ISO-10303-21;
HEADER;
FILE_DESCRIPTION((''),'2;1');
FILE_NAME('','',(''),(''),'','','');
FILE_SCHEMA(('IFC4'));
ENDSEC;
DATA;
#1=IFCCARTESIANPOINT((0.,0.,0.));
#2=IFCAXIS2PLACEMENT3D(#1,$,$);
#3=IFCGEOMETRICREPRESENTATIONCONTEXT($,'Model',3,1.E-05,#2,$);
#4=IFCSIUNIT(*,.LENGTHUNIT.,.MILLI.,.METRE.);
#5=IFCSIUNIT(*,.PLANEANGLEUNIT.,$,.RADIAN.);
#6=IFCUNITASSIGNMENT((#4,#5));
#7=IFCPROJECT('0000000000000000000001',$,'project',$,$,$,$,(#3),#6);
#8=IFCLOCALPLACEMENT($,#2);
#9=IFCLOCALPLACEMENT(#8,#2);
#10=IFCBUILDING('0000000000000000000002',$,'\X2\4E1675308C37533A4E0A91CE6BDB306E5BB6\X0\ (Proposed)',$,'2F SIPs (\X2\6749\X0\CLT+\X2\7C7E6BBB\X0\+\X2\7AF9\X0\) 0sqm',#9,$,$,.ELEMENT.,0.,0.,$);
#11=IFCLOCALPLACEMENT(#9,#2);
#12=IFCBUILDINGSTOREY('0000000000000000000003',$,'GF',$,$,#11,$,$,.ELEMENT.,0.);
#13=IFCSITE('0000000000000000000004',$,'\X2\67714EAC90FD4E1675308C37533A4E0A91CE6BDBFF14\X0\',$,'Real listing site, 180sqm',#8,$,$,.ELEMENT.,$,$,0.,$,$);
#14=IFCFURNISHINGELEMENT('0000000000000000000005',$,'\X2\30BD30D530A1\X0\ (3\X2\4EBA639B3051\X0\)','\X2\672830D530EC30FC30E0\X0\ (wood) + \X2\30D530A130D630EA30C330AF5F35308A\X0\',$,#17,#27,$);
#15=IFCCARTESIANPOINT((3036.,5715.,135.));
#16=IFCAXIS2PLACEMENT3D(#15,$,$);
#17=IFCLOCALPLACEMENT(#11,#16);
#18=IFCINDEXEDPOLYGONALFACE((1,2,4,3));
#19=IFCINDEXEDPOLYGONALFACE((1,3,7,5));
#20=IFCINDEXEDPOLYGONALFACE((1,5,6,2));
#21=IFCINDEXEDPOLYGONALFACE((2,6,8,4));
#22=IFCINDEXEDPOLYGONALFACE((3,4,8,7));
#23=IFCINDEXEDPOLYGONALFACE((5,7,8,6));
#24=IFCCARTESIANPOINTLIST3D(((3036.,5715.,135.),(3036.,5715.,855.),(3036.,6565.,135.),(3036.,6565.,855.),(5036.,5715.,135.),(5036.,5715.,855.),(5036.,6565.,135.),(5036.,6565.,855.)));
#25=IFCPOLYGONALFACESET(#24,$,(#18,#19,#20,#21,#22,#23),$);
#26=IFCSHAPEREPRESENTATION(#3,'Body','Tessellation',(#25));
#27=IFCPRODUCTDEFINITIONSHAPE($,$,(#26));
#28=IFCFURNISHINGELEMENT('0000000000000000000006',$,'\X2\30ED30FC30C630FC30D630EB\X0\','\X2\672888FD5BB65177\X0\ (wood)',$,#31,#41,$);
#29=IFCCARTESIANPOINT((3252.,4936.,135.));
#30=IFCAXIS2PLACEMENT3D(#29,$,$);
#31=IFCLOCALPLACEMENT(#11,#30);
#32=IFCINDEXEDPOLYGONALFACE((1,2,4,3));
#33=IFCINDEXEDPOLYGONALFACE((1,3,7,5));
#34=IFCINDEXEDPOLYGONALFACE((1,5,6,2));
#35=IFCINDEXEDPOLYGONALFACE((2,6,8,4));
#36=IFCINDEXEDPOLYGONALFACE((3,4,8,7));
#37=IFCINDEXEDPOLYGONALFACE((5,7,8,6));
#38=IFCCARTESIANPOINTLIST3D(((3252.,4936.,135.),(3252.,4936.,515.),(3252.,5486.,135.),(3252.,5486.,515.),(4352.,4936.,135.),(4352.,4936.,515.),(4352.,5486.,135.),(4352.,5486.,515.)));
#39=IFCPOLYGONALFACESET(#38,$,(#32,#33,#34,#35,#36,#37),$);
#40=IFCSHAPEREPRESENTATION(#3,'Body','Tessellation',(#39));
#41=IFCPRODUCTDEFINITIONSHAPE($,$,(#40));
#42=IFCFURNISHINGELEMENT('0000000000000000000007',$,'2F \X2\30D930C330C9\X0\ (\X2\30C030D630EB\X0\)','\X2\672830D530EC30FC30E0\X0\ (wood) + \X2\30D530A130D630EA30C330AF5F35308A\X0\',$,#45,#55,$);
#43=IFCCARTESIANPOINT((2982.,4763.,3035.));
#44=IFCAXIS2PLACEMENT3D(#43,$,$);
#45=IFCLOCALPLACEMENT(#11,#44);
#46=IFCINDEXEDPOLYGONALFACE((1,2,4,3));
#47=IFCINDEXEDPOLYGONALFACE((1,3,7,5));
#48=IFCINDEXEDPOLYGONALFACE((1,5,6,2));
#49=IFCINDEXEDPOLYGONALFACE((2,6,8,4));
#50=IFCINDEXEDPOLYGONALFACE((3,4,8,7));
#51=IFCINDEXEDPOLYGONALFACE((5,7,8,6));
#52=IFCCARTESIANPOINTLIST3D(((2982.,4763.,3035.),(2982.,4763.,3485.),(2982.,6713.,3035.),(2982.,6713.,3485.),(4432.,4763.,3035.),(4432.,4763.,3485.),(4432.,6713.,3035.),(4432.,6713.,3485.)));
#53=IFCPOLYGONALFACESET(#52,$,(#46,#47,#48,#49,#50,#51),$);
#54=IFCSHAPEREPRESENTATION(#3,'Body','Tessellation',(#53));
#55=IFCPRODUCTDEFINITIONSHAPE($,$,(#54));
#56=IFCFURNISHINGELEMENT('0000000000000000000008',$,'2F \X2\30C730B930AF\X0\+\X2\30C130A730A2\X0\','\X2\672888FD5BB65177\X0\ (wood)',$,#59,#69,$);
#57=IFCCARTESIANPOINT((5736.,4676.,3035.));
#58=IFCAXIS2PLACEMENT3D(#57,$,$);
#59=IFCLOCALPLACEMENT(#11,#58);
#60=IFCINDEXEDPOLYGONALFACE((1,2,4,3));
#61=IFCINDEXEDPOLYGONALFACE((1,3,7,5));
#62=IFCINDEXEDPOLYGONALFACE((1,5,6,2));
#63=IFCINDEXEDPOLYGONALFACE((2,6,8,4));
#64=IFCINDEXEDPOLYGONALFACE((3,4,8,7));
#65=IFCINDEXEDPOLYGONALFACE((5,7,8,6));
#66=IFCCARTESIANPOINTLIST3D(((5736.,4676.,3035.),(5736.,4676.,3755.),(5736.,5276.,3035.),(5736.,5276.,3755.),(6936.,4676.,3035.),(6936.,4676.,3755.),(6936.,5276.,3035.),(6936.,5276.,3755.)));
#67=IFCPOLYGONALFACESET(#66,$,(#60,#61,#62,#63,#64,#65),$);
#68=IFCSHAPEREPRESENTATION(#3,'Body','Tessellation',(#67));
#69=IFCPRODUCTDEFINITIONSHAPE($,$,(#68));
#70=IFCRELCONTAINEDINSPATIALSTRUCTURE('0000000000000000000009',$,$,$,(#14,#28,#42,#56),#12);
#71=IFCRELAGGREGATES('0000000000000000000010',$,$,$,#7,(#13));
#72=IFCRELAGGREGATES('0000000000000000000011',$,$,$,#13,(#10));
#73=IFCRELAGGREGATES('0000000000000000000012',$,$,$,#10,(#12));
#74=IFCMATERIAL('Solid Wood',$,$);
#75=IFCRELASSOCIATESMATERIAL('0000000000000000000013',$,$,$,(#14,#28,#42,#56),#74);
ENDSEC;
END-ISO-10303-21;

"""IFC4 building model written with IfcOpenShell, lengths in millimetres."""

from ifc_helpers import new_model, si_unit, frame, frame_2d, origin, place, context, project, spatial, rectangle, extrude, material, element, save


model = new_model("IFC4")

# Units and contexts
model_context = context("Model", 3, precision=1e-05, world=origin())
ifc_project = project(units=[si_unit("LENGTHUNIT", "METRE", prefix="MILLI"), si_unit("PLANEANGLEUNIT", "RADIAN")], contexts=[model_context])

# Site, building, storey
site_placement = place(None, origin())
site = spatial("IfcSite", under=ifc_project, at=site_placement, Name="東京都世田谷区上野毛４", ObjectType="Real listing site, 180sqm", CompositionType="ELEMENT", RefElevation=0.0)
building_placement = place(site_placement, origin())
building = spatial("IfcBuilding", under=site, at=building_placement, Name="世田谷区上野毛の家 (Proposed)", ObjectType="2F SIPs (杉CLT+籾殻+竹) 0sqm", CompositionType="ELEMENT", ElevationOfRefHeight=0.0, ElevationOfTerrain=0.0)
storey_placement = place(building_placement, origin())
storey = spatial("IfcBuildingStorey", under=building, at=storey_placement, Name="GF", CompositionType="ELEMENT", Elevation=0.0)

# Shared definitions
ifc_material_1 = material(Name="Solid Wood")

# Furnishing elements
furnishing_1_placement = place(storey_placement, frame((3036.0, 5715.0, 135.0)))
element("IfcFurnishingElement", 1, at=furnishing_1_placement, inside=storey, material=ifc_material_1, Name="ソファ (3人掛け)", Description="木フレーム (wood) + ファブリック張り", context=model_context, shape_type="SweptSolid", body=[
    extrude(rectangle(XDim=2000.0, YDim=850.0, at=frame_2d((1000.0, 425.0))), frame((3036.0, 5715.0, 135.0)), (0.0, 0.0, 1.0), 720.0),
])
furnishing_2_placement = place(storey_placement, frame((3252.0, 4936.0, 135.0)))
element("IfcFurnishingElement", 2, at=furnishing_2_placement, inside=storey, material=ifc_material_1, Name="ローテーブル", Description="木製家具 (wood)", context=model_context, shape_type="SweptSolid", body=[
    extrude(rectangle(XDim=1100.0, YDim=550.0, at=frame_2d((550.0, 275.0))), frame((3252.0, 4936.0, 135.0)), (0.0, 0.0, 1.0), 380.0),
])
furnishing_3_placement = place(storey_placement, frame((2982.0, 4763.0, 3035.0)))
element("IfcFurnishingElement", 3, at=furnishing_3_placement, inside=storey, material=ifc_material_1, Name="2F ベッド (ダブル)", Description="木フレーム (wood) + ファブリック張り", context=model_context, shape_type="SweptSolid", body=[
    extrude(rectangle(XDim=1450.0, YDim=1950.0, at=frame_2d((725.0, 975.0))), frame((2982.0, 4763.0, 3035.0)), (0.0, 0.0, 1.0), 450.0),
])
furnishing_4_placement = place(storey_placement, frame((5736.0, 4676.0, 3035.0)))
element("IfcFurnishingElement", 4, at=furnishing_4_placement, inside=storey, material=ifc_material_1, Name="2F デスク+チェア", Description="木製家具 (wood)", context=model_context, shape_type="SweptSolid", body=[
    extrude(rectangle(XDim=1200.0, YDim=600.0, at=frame_2d((600.0, 300.0))), frame((5736.0, 4676.0, 3035.0)), (0.0, 0.0, 1.0), 720.0),
])

save(model, "model.ifc")
